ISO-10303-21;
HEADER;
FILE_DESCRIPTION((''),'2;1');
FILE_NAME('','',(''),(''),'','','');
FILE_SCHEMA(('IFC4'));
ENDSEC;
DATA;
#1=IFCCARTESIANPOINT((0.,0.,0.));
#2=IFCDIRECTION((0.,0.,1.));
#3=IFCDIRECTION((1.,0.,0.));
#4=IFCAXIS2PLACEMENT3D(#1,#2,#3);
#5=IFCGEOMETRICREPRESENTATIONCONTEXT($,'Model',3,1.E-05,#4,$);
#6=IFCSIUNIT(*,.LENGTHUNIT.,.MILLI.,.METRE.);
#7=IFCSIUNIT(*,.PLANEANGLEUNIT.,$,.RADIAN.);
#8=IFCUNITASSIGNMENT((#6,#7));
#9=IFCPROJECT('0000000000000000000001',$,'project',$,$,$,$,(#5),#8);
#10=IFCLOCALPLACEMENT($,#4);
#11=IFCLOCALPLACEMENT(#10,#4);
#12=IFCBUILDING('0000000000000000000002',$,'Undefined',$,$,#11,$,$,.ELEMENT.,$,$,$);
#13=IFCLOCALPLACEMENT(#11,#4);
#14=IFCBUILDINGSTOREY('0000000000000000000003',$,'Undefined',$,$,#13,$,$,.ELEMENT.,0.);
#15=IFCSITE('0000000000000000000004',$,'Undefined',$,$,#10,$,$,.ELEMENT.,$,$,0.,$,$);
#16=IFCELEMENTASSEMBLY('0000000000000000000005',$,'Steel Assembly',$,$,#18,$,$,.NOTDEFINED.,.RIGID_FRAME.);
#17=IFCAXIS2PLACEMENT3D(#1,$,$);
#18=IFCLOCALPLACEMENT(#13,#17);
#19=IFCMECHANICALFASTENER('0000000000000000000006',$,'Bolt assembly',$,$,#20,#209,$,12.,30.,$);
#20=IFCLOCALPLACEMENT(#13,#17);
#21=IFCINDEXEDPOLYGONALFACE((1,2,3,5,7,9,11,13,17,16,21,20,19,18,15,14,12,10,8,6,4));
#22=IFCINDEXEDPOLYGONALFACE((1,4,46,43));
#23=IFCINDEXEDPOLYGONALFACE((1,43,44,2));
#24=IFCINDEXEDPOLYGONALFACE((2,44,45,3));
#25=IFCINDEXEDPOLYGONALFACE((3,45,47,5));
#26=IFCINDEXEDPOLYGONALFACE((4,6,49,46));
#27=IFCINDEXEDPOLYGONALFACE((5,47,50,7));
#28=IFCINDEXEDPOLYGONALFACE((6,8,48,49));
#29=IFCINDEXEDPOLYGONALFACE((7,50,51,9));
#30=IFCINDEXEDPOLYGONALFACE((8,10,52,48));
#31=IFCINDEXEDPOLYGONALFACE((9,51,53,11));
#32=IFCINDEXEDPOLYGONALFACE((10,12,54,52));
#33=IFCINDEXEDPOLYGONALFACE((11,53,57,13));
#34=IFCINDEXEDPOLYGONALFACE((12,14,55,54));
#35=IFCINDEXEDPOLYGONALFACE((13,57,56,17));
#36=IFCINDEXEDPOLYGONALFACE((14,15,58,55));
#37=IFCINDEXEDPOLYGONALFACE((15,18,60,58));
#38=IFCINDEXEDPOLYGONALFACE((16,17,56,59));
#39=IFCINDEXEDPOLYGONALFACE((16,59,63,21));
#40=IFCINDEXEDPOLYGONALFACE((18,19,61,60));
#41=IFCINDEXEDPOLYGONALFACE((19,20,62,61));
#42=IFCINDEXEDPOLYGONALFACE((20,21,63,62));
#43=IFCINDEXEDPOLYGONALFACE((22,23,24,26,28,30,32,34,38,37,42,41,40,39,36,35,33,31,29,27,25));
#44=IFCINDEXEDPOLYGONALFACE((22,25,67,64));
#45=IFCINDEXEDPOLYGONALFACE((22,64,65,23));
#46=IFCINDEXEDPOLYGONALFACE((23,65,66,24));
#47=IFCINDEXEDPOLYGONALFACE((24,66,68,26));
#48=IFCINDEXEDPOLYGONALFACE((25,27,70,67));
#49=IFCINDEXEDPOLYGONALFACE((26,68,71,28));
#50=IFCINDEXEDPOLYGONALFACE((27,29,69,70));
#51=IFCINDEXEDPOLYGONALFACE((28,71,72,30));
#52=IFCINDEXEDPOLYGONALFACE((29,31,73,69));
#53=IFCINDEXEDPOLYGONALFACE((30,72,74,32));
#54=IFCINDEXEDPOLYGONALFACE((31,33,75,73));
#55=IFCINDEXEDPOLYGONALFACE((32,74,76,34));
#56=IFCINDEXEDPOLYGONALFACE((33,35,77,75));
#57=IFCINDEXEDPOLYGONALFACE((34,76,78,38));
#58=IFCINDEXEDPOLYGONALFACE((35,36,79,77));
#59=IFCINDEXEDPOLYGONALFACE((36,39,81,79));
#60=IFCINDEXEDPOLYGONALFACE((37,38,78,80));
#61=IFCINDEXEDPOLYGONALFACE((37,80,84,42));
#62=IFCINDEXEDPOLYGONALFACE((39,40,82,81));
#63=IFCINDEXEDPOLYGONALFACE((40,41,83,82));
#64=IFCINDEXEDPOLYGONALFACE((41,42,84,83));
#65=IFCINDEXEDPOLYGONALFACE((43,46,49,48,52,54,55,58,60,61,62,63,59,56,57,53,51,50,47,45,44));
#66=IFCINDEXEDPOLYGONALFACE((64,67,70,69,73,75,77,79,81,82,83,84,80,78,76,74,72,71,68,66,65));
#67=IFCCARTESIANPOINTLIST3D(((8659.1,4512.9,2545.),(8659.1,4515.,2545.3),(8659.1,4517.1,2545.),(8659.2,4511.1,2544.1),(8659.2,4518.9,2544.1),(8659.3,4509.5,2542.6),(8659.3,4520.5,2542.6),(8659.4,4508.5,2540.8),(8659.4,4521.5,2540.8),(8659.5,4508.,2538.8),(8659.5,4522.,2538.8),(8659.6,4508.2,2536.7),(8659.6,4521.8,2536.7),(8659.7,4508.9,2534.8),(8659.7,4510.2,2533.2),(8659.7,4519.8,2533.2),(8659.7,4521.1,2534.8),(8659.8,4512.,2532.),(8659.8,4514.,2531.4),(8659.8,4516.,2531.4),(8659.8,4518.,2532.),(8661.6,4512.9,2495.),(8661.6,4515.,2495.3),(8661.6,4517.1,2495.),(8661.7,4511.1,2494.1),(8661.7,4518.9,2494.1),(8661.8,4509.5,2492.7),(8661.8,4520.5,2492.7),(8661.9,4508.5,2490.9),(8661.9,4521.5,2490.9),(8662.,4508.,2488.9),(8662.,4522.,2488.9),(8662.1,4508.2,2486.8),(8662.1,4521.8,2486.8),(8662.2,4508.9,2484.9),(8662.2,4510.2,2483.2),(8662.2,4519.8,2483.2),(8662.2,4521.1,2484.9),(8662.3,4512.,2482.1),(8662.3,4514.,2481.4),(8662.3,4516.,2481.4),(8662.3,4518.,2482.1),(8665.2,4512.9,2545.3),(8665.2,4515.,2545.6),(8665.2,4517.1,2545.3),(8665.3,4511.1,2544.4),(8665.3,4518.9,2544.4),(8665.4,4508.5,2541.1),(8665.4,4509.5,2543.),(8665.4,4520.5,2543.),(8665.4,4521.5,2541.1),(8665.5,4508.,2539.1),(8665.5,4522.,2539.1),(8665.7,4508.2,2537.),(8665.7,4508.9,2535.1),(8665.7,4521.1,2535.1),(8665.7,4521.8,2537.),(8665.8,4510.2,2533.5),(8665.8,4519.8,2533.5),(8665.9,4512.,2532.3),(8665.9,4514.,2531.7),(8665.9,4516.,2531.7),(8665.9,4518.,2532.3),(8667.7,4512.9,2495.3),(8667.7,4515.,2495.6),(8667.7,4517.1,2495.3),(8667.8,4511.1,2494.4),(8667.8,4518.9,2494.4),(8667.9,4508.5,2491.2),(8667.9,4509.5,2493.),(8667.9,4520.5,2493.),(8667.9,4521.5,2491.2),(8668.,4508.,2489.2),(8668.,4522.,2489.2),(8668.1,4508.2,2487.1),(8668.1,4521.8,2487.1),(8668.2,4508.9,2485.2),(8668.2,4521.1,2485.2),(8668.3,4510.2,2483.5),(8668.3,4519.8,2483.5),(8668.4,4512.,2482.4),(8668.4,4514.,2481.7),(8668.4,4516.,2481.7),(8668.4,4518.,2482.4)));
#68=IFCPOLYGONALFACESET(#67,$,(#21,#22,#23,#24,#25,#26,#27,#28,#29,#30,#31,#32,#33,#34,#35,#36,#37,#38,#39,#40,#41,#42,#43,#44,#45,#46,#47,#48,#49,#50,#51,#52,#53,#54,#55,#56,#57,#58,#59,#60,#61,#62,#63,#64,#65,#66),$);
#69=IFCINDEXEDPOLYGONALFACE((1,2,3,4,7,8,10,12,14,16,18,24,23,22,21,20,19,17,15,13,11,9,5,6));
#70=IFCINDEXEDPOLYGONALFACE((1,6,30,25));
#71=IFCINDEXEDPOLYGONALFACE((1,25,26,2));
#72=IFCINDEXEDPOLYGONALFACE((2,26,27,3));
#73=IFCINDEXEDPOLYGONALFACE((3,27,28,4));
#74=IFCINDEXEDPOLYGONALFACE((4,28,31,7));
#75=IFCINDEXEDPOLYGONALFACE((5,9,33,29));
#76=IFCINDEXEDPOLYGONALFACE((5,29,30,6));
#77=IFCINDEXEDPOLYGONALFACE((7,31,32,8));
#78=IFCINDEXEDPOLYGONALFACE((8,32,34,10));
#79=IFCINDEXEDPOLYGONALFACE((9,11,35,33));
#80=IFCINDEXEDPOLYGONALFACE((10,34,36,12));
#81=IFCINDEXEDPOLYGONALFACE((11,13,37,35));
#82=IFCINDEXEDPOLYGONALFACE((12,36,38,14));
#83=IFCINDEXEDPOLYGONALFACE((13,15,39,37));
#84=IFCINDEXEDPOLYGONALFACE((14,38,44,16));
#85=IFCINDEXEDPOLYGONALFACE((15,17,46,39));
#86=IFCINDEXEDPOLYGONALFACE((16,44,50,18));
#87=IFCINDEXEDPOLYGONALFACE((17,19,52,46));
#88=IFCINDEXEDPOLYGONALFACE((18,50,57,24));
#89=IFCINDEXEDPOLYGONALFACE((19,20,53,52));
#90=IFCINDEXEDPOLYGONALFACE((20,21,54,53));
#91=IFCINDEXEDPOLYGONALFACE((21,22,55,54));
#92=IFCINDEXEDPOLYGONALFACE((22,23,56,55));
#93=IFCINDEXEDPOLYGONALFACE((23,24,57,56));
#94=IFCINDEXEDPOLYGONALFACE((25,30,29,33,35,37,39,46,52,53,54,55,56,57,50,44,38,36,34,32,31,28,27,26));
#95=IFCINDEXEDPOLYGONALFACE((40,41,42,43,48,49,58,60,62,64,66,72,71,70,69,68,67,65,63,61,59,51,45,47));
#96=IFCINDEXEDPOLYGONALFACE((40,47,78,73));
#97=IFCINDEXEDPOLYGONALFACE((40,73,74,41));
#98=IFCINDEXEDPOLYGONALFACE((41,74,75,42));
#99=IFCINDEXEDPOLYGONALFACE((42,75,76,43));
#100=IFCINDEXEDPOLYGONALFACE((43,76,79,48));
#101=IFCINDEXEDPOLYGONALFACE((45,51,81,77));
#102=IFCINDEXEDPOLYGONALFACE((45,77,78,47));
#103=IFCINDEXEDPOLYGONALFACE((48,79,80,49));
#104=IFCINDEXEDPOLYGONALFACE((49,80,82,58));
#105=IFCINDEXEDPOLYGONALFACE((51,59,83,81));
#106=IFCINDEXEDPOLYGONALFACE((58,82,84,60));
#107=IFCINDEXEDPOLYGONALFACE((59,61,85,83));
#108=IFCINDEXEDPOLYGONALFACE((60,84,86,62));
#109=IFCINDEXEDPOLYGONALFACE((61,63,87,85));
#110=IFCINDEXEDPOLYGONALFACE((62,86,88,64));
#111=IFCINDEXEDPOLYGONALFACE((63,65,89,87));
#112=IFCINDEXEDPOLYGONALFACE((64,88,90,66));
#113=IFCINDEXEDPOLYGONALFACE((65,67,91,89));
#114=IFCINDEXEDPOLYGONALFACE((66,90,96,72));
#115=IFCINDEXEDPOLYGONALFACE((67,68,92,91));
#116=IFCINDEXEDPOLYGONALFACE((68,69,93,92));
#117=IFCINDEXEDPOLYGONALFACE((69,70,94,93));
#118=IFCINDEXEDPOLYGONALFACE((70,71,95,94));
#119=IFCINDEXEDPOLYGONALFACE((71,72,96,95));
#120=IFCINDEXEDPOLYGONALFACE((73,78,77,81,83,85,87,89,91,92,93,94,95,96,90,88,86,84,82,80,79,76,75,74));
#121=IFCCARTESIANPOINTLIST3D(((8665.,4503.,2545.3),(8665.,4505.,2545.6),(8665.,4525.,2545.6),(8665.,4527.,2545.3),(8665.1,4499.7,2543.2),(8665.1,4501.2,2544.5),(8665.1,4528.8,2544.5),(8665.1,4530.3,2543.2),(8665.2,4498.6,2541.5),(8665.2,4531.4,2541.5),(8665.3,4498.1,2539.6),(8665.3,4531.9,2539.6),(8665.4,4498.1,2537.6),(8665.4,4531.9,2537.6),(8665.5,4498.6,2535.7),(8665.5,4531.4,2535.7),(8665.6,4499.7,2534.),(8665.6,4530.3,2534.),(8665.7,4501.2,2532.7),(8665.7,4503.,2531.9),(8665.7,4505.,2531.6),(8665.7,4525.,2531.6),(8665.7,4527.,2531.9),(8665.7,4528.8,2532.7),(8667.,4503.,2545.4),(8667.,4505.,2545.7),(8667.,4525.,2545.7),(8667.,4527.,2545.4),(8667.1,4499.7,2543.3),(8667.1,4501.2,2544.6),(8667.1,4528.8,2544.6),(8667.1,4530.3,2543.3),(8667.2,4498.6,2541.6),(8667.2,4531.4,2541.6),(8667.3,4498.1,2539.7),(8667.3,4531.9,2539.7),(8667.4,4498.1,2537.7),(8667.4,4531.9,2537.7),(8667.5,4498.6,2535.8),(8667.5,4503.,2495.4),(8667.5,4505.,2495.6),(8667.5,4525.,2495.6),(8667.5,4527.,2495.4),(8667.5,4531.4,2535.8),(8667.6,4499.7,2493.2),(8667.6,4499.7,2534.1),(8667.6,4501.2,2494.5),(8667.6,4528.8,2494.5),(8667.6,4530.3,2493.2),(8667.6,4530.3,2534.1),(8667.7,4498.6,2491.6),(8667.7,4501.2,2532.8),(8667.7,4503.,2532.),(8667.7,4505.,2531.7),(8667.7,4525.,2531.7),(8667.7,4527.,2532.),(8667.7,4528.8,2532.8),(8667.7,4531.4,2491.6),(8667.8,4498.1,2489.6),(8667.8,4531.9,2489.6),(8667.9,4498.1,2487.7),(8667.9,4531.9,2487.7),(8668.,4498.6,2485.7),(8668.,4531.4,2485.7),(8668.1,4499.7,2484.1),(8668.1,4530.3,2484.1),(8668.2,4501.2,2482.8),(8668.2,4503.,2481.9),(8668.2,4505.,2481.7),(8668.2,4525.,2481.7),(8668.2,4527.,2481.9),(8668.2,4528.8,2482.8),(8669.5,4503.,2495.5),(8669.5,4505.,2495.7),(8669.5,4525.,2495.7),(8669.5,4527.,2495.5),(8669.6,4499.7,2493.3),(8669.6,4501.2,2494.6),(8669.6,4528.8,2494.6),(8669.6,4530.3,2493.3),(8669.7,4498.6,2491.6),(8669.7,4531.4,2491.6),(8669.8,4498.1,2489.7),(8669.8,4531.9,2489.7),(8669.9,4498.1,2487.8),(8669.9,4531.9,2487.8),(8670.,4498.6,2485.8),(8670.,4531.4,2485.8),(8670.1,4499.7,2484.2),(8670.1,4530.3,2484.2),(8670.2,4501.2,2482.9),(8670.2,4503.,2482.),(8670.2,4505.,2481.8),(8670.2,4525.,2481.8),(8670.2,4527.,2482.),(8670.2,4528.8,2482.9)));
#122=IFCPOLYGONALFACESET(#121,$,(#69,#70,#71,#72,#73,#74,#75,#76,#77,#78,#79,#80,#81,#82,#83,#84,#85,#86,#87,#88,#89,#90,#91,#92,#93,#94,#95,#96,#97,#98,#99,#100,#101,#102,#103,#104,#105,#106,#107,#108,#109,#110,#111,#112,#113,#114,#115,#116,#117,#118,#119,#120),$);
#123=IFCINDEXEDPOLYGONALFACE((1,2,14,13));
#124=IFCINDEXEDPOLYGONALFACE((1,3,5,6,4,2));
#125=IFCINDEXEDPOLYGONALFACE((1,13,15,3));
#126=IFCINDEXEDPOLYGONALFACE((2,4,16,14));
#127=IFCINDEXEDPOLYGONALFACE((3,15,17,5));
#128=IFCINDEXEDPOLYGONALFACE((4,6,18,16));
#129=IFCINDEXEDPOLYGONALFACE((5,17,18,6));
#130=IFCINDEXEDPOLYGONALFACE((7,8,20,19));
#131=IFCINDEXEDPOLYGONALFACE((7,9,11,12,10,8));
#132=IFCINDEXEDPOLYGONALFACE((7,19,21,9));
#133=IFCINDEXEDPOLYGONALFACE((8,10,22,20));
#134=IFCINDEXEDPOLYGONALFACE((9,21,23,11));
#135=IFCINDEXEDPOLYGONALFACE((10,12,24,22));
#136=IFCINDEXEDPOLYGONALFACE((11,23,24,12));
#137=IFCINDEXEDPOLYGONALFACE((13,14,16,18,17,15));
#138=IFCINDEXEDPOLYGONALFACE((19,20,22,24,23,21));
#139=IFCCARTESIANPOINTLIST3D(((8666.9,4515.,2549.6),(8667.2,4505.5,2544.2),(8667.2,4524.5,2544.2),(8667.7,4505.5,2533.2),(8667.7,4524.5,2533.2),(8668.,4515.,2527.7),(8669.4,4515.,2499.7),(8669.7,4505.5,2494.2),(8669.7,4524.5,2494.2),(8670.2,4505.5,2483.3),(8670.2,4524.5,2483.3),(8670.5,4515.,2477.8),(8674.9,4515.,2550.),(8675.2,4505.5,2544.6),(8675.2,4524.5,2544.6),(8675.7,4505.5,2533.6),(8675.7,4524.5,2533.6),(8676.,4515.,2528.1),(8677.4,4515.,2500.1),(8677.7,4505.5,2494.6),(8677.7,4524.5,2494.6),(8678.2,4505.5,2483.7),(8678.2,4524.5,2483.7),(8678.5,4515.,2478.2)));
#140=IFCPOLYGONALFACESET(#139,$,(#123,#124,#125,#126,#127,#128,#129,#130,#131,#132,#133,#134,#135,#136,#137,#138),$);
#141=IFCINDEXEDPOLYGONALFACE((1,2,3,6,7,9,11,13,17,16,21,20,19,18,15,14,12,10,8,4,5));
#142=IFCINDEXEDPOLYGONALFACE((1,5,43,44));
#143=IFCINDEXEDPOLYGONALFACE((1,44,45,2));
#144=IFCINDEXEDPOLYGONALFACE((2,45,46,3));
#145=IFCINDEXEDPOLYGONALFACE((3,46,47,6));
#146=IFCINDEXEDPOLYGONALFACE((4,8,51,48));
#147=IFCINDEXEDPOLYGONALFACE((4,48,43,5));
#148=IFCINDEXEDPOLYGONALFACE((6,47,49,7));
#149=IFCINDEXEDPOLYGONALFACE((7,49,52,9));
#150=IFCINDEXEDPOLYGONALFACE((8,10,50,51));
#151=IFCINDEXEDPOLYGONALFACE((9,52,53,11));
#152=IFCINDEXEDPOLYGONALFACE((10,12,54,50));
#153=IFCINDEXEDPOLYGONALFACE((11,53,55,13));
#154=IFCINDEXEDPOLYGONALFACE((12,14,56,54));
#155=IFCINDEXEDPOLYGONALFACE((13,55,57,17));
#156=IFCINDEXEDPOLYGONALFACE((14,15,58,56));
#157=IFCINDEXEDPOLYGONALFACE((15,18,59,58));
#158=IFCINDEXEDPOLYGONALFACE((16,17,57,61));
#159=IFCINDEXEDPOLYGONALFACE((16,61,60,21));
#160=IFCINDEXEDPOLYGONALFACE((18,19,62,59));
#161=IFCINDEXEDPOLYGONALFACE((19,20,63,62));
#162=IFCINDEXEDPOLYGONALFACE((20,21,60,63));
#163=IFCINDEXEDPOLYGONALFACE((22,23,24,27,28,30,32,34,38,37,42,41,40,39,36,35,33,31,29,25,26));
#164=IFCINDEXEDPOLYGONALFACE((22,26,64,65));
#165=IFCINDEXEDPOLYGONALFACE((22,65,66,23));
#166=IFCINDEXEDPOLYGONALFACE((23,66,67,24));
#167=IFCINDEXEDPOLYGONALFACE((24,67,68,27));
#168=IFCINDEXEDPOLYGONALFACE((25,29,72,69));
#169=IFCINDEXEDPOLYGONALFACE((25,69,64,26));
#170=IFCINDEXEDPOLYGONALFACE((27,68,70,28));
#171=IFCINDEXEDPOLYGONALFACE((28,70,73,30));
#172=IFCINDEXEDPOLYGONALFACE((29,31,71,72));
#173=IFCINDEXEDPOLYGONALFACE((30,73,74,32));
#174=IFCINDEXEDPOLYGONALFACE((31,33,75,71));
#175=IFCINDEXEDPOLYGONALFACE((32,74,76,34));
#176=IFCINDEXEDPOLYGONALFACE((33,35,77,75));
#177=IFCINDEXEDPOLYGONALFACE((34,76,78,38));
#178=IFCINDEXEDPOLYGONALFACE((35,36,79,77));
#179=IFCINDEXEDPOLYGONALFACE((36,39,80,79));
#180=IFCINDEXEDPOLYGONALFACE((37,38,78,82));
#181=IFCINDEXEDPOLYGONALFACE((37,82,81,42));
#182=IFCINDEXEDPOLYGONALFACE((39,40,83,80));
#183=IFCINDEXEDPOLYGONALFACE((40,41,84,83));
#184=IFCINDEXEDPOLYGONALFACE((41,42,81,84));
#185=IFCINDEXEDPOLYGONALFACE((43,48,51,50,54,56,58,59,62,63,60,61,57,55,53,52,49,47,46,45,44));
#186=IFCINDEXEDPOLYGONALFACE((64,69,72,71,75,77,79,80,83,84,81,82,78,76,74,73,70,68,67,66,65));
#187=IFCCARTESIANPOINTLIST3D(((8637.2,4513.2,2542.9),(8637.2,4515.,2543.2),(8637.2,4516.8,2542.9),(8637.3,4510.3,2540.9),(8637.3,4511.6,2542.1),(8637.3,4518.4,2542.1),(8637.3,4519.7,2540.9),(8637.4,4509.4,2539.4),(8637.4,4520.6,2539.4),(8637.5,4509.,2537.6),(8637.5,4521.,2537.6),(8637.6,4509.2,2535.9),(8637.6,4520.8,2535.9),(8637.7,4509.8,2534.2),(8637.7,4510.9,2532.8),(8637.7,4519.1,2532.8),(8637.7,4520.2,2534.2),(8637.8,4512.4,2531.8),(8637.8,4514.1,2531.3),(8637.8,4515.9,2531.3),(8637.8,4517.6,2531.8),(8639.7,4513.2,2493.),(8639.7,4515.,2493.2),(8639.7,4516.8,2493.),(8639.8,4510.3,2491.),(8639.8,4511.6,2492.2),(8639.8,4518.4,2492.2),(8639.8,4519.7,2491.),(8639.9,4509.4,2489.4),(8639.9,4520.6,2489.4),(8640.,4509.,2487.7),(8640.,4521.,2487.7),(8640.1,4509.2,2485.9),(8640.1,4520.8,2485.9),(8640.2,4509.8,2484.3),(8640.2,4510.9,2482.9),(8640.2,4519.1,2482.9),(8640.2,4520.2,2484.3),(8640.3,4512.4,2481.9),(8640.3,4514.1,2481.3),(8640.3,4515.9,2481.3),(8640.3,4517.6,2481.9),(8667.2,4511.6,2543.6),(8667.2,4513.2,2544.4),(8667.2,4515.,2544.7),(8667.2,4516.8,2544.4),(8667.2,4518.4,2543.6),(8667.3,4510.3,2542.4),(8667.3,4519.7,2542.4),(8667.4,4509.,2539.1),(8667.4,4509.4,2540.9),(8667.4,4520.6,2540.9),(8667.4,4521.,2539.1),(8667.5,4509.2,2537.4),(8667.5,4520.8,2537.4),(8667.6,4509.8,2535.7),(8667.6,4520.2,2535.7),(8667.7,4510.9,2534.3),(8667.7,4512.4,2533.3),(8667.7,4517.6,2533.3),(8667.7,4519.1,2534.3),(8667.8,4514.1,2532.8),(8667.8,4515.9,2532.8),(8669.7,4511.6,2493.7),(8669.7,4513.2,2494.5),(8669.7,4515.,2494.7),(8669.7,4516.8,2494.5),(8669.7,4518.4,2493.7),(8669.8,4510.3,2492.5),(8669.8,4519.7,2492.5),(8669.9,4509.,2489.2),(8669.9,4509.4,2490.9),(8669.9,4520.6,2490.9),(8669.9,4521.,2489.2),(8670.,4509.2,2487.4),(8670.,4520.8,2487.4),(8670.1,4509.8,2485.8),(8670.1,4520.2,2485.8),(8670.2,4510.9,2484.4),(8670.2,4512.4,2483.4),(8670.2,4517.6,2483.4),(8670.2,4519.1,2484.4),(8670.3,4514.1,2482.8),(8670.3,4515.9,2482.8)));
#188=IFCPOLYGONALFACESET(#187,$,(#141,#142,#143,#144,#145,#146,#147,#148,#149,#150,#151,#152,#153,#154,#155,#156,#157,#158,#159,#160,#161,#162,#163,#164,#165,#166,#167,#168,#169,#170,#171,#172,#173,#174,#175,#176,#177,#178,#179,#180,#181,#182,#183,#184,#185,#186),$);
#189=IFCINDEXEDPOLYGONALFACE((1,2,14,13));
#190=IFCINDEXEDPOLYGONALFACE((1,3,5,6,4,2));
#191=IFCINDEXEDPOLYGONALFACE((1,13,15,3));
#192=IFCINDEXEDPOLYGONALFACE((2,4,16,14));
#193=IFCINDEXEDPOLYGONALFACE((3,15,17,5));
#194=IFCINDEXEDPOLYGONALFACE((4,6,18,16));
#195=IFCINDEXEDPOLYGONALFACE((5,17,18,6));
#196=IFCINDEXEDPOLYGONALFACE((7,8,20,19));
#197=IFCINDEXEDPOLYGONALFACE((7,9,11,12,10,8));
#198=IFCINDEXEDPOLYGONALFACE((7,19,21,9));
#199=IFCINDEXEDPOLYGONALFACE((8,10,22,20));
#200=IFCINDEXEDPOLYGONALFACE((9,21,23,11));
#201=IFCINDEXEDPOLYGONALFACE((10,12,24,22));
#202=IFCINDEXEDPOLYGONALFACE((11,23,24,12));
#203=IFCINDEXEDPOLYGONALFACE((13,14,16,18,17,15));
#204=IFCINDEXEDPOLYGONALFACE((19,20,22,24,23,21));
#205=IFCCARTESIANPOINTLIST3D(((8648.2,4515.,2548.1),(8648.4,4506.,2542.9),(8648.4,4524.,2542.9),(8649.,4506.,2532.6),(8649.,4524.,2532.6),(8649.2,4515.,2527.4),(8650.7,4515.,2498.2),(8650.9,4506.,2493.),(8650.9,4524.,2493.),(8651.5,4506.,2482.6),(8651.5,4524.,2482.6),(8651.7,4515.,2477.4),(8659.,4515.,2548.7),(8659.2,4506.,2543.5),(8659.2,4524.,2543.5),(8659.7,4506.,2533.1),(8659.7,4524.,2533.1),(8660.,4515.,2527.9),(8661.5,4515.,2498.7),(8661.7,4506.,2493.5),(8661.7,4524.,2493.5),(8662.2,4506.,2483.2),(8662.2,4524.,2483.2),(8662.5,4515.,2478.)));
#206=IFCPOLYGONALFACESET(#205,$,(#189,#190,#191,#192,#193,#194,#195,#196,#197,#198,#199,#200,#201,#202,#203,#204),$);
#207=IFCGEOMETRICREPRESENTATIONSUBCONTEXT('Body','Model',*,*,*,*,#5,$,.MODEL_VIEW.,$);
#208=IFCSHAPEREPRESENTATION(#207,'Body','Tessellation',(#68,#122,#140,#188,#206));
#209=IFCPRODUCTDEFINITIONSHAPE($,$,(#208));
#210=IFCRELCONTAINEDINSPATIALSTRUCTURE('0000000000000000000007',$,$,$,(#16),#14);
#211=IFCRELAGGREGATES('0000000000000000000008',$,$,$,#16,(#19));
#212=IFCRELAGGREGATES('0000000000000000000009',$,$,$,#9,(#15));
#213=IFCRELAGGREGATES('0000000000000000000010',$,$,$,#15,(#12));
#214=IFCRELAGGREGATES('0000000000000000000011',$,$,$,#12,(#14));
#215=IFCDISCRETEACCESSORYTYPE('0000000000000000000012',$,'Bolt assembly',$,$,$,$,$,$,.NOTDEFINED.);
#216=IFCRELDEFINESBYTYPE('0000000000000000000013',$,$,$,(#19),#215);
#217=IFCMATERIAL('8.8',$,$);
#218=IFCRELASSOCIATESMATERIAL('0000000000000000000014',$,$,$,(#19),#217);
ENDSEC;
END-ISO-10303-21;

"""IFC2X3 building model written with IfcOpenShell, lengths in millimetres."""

from ifc_helpers import new_model, si_unit, frame, frame_2d, origin_with_axes, origin_2d_with_axis, place, context, subcontext, project, spatial, polyline, circle_curve, parameter, trimmed, segment, composite_curve, circle, outline, extrude, source, transform, mapped, material, type_object, element, aggregate, save


model = new_model("IFC2X3")

# Units and contexts
model_context = context("Model", 3, precision=1e-05, world=origin_with_axes())
body_context = subcontext(model_context, "Body", "Model", "MODEL_VIEW")
ifc_project = project(units=[si_unit("LENGTHUNIT", "METRE", prefix="MILLI"), si_unit("PLANEANGLEUNIT", "RADIAN")], contexts=[model_context])

# Site, building, storey
site_placement = place(None, origin_with_axes())
site = spatial("IfcSite", under=ifc_project, at=site_placement, Name="Undefined", CompositionType="ELEMENT", RefElevation=0.0)
building_placement = place(site_placement, origin_with_axes())
building = spatial("IfcBuilding", under=site, at=building_placement, Name="Undefined", CompositionType="ELEMENT")
storey_placement = place(building_placement, origin_with_axes())
storey = spatial("IfcBuildingStorey", under=building, at=storey_placement, Name="Undefined", CompositionType="ELEMENT", Elevation=0.0)

# Element assembly
assembly_1_placement = place(storey_placement, origin_with_axes())
assembly_1 = element("IfcElementAssembly", 1, at=assembly_1_placement, inside=storey, Name="Steel Assembly", AssemblyPlace="NOTDEFINED", PredefinedType="RIGID_FRAME")

# Mechanical fastener
discrete_accessory_type_1 = type_object("IfcDiscreteAccessoryType", Name="Bolt assembly")
ifc_material_1 = material(Name="8.8")
shared_shape_1 = source(origin_with_axes(), body_context, "Body", "SweptSolid", [
    extrude(circle(Radius=7.0, at=origin_2d_with_axis()), frame((0.0, -3.1, 0.0), z_axis=(0.0, 1.0, 0.0), x_axis=(1.0, 0.0, 0.0)), (0.0, 0.0, 1.0), 6.1),
    extrude(outline(composite_curve([segment(polyline([(7.0, 10.0), (7.0, -10.0)]), True, "CONTINUOUS"), segment(trimmed(circle_curve(frame_2d((0.0, -10.0), x_axis=(1.0, 0.0)), 7.0), [parameter(0.0)], [parameter(3.1416)], False, "PARAMETER"), True, "CONTINUOUS"), segment(polyline([(-7.0, -10.0), (-7.0, 10.0)]), True, "CONTINUOUS"), segment(trimmed(circle_curve(frame_2d((0.0, 10.0), x_axis=(-1.0, 0.0)), 7.0), [parameter(0.0)], [parameter(3.1416)], False, "PARAMETER"), True, "DISCONTINUOUS")], self_intersect=False)), frame((0.0, -4.9, 0.0), z_axis=(0.0, 1.0, 0.0), x_axis=(1.0, 0.0, 0.0)), (0.0, 0.0, 1.0), 2.0),
    extrude(outline(polyline([(11.0, 0.0), (5.5, 9.5), (-5.5, 9.5), (-11.0, 0.0), (-5.5, -9.5), (5.5, -9.5), (11.0, 0.0)])), frame((0.0, -13.0, 0.0), z_axis=(0.0, 1.0, 0.0), x_axis=(1.0, 0.0, 0.0)), (0.0, 0.0, 1.0), 8.0),
    extrude(circle(Radius=6.0, at=origin_2d_with_axis()), frame((0.0, -5.0, 0.0), z_axis=(0.0, 1.0, 0.0), x_axis=(1.0, 0.0, 0.0)), (0.0, 0.0, 1.0), 30.0),
    extrude(outline(polyline([(10.4, 0.0), (5.2, 9.0), (-5.2, 9.0), (-10.4, 0.0), (-5.2, -9.0), (5.2, -9.0), (10.4, 0.0)])), frame((0.0, 3.0, 0.0), z_axis=(0.0, 1.0, 0.0), x_axis=(1.0, 0.0, 0.0)), (0.0, 0.0, 1.0), 10.8),
])
mechanical_fastener_1_placement = place(assembly_1_placement, frame((8666.2, 4560.0, 2463.5), z_axis=(0.0, -1.0, 0.0), x_axis=(-0.049938, 0.0, 0.998752)))
mechanical_fastener_1 = element("IfcMechanicalFastener", 2, at=mechanical_fastener_1_placement, type_object=discrete_accessory_type_1, material=ifc_material_1, Name="Bolt assembly", NominalDiameter=12.0, NominalLength=30.0, context=body_context, shape_type="MappedRepresentation", body=[
    mapped(shared_shape_1, transform((25.0, 0.0, 45.0))),
    mapped(shared_shape_1, transform((75.0, 0.0, 45.0))),
])
aggregate(assembly_1, [mechanical_fastener_1])

save(model, "model.ifc")
